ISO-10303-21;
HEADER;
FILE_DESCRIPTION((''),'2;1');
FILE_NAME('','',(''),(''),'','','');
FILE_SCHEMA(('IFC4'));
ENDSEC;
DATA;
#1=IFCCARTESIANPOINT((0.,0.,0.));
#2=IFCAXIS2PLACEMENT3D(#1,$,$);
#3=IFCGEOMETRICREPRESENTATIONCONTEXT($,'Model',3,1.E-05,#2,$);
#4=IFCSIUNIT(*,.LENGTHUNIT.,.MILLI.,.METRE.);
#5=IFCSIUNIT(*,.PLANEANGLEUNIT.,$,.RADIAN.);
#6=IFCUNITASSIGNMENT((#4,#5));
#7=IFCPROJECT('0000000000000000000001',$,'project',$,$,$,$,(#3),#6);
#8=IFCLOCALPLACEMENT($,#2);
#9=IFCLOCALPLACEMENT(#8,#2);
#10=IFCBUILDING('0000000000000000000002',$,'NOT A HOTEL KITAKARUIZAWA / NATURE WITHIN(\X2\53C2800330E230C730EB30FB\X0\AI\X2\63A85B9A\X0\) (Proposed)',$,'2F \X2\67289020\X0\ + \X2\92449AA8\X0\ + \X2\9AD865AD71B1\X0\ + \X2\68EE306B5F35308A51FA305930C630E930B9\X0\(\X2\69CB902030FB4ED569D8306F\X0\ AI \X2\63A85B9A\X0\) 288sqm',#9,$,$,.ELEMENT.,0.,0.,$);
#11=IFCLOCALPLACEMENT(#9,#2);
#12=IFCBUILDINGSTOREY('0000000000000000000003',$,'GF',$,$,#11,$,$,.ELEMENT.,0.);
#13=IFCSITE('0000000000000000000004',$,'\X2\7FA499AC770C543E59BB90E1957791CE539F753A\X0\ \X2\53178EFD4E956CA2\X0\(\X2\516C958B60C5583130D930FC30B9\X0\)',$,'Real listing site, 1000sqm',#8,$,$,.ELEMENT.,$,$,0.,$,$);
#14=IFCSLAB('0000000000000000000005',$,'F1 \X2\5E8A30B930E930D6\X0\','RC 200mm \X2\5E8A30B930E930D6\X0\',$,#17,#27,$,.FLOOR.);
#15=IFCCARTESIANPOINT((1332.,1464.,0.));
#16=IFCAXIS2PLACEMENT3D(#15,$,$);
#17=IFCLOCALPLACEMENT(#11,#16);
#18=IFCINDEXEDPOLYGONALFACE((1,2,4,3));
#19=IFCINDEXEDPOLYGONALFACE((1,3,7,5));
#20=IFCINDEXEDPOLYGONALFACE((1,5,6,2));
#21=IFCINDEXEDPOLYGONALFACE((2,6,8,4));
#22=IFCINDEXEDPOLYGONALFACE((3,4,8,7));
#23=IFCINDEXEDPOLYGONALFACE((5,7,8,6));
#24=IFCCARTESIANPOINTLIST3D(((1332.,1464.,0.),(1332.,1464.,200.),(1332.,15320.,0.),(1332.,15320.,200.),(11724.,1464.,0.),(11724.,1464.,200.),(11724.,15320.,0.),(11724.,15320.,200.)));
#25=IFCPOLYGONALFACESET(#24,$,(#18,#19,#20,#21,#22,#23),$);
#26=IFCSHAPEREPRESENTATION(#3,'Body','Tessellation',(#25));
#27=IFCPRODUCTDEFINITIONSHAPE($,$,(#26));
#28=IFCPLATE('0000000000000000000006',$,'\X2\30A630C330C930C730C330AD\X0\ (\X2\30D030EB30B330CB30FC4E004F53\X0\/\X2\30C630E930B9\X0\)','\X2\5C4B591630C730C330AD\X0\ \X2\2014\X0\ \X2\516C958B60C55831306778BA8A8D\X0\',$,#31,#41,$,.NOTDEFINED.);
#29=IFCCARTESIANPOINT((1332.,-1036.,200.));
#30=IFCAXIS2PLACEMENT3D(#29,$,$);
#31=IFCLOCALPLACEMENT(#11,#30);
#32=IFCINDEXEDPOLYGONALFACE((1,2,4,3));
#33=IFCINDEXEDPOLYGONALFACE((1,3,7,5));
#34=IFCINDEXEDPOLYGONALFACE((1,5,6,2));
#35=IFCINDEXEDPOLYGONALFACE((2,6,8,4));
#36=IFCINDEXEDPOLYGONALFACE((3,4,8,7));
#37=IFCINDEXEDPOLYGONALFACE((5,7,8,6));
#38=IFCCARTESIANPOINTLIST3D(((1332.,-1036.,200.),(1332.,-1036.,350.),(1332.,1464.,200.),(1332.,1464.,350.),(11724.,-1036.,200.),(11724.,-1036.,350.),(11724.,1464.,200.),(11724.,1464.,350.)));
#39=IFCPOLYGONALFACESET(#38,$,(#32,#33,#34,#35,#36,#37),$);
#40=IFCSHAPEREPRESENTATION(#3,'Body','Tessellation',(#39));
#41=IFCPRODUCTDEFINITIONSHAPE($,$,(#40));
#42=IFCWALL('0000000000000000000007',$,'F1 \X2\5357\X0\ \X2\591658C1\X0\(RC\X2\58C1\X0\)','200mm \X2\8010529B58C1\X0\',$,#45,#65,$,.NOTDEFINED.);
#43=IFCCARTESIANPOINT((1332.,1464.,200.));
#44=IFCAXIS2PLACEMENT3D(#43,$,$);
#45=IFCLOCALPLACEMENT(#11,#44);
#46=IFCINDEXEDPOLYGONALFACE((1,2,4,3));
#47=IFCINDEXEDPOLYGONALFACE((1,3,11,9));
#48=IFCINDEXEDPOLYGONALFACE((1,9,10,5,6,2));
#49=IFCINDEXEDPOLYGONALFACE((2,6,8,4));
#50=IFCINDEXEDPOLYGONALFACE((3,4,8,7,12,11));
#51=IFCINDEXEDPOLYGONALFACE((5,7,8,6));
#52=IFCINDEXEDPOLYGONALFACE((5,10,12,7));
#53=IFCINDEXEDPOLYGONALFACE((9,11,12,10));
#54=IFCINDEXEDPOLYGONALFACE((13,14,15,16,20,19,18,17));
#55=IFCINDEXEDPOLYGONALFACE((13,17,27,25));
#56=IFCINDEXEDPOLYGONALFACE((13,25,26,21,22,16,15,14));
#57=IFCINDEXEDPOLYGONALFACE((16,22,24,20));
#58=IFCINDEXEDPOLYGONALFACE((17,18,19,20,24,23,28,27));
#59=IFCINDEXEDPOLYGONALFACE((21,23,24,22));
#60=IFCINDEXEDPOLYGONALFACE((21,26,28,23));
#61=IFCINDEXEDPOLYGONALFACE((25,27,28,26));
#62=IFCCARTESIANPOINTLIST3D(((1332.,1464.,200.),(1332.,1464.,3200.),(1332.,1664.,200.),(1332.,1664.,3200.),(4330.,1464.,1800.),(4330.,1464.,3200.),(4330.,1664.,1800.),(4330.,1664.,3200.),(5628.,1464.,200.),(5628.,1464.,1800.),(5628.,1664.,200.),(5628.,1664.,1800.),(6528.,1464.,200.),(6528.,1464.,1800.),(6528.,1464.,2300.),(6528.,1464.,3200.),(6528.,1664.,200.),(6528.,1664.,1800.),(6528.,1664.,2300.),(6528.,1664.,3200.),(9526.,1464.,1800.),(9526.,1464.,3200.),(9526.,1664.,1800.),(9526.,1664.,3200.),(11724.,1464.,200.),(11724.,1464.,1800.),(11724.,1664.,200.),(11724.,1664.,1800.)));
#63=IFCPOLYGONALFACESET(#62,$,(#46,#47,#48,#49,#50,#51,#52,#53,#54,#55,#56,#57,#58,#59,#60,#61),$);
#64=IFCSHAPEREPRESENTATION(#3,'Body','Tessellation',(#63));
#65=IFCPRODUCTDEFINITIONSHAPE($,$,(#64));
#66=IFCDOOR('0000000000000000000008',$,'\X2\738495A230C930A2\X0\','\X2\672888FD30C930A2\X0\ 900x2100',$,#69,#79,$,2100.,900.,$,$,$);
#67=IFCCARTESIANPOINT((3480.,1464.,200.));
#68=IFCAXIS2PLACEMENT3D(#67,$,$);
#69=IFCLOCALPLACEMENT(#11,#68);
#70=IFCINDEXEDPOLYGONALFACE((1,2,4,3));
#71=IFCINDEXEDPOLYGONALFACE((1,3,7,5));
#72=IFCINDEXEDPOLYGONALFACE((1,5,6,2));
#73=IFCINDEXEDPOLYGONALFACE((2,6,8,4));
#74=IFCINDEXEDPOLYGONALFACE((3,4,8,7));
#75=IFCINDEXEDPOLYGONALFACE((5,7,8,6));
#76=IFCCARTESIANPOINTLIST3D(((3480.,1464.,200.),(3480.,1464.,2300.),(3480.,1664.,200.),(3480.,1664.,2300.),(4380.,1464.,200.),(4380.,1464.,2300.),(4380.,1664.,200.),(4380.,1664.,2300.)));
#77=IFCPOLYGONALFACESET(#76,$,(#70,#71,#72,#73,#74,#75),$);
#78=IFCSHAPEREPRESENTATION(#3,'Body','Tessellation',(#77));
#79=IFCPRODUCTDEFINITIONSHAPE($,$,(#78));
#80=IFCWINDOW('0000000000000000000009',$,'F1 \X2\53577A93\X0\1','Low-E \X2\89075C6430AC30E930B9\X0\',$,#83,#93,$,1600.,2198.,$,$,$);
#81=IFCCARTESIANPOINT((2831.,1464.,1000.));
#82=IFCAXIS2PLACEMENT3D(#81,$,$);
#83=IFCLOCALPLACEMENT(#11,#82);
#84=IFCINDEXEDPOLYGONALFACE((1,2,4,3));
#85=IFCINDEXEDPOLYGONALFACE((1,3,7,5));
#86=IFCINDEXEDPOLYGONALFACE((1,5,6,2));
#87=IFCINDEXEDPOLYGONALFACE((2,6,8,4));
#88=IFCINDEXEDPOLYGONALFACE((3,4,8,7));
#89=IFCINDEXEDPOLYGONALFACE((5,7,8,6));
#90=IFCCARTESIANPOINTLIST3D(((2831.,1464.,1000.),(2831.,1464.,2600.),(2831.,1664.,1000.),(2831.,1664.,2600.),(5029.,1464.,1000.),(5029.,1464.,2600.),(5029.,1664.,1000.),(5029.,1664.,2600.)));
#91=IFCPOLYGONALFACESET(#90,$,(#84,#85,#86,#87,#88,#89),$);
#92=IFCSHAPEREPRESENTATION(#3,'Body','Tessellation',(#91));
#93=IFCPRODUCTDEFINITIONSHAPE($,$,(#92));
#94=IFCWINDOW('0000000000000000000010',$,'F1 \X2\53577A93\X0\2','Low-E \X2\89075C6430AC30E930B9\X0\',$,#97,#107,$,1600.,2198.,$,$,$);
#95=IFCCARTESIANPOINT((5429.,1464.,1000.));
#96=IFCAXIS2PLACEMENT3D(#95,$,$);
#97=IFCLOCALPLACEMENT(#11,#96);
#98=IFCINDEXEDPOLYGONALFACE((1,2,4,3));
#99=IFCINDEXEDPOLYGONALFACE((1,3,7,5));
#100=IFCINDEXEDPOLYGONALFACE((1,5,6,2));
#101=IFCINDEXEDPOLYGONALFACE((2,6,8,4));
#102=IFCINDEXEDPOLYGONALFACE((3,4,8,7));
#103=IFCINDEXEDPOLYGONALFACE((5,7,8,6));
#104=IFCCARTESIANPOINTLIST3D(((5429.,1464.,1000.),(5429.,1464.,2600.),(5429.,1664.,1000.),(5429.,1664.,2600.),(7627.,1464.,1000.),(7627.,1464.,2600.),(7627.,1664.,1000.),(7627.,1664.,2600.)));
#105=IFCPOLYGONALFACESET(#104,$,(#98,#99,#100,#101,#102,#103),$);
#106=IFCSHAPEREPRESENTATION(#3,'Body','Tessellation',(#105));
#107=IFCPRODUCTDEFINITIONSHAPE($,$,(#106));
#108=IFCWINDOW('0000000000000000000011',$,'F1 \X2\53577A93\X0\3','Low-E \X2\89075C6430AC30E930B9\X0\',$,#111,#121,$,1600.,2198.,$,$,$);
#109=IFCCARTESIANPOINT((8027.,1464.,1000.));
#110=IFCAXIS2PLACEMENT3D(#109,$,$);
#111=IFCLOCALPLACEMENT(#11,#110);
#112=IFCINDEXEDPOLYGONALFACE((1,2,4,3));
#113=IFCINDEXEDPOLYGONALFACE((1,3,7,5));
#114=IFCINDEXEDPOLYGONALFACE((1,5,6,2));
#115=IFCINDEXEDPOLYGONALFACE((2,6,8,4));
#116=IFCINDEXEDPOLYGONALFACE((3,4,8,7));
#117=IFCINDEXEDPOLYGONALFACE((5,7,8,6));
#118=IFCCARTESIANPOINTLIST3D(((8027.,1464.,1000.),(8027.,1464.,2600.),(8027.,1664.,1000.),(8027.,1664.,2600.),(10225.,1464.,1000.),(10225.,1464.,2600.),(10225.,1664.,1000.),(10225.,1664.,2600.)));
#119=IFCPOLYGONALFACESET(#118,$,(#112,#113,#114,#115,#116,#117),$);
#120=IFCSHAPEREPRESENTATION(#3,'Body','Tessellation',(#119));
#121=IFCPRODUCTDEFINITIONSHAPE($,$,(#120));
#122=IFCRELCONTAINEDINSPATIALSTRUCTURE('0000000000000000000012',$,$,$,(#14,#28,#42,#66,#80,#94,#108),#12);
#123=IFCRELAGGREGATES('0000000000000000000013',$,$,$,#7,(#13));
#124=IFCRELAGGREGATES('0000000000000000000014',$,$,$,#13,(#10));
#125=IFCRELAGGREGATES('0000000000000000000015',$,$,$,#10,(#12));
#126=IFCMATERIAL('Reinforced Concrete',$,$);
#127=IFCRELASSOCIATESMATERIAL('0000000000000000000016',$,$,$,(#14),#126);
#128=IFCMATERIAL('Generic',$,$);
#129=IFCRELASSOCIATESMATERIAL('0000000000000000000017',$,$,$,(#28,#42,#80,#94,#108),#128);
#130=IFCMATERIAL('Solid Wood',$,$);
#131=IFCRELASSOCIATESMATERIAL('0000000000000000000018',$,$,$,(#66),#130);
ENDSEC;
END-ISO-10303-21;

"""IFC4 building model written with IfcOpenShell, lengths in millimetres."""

from ifc_helpers import new_model, si_unit, frame, frame_2d, origin, place, context, project, spatial, rectangle, extrude, material, element, fill, save


model = new_model("IFC4")

# Units and contexts
model_context = context("Model", 3, precision=1e-05, world=origin())
ifc_project = project(units=[si_unit("LENGTHUNIT", "METRE", prefix="MILLI"), si_unit("PLANEANGLEUNIT", "RADIAN")], contexts=[model_context])

# Site, building, storey
site_placement = place(None, origin())
site = spatial("IfcSite", under=ifc_project, at=site_placement, Name="群馬県吾妻郡長野原町 北軽井沢(公開情報ベース)", ObjectType="Real listing site, 1000sqm", CompositionType="ELEMENT", RefElevation=0.0)
building_placement = place(site_placement, origin())
building = spatial("IfcBuilding", under=site, at=building_placement, Name="NOT A HOTEL KITAKARUIZAWA / NATURE WITHIN(参考モデル・AI推定) (Proposed)", ObjectType="2F 木造 + 鉄骨 + 高断熱 + 森に張り出すテラス(構造・仕様は AI 推定) 288sqm", CompositionType="ELEMENT", ElevationOfRefHeight=0.0, ElevationOfTerrain=0.0)
storey_placement = place(building_placement, origin())
storey = spatial("IfcBuildingStorey", under=building, at=storey_placement, Name="GF", CompositionType="ELEMENT", Elevation=0.0)

# Slab
ifc_material_1 = material(Name="Reinforced Concrete")
slab_placement = place(storey_placement, frame((1332.0, 1464.0, 0.0)))
element("IfcSlab", 1, at=slab_placement, inside=storey, material=ifc_material_1, Name="F1 床スラブ", Description="RC 200mm 床スラブ", PredefinedType="FLOOR", context=model_context, shape_type="SweptSolid", body=[
    extrude(rectangle(XDim=10392.0, YDim=13856.0, at=frame_2d((5196.0, 6928.0))), frame((1332.0, 1464.0, 0.0)), (0.0, 0.0, 1.0), 200.0),
])

# Plate
ifc_material_2 = material(Name="Generic")
plate_placement = place(storey_placement, frame((1332.0, -1036.0, 200.0)))
element("IfcPlate", 2, at=plate_placement, inside=storey, material=ifc_material_2, Name="ウッドデッキ (バルコニー一体/テラス)", Description="屋外デッキ — 公開情報で確認", PredefinedType="NOTDEFINED", context=model_context, shape_type="SweptSolid", body=[
    extrude(rectangle(XDim=10392.0, YDim=2500.0, at=frame_2d((5196.0, 1250.0))), frame((1332.0, -1036.0, 200.0)), (0.0, 0.0, 1.0), 150.0),
])

# Wall, openings, door, windows
wall_1_placement = place(storey_placement, frame((1332.0, 1464.0, 200.0)))
wall_1 = element("IfcWall", 3, at=wall_1_placement, inside=storey, material=ifc_material_2, Name="F1 南 外壁(RC壁)", Description="200mm 耐力壁", PredefinedType="NOTDEFINED", context=model_context, shape_type="SweptSolid", body=[
    extrude(rectangle(XDim=10392.0, YDim=200.0, at=frame_2d((5196.0, 100.0))), frame((1332.0, 1464.0, 200.0)), (0.0, 0.0, 1.0), 3000.0),
])
opening_1_placement = place(storey_placement, frame((3480.0, 1464.0, 200.0)))
opening_1 = element("IfcOpeningElement", 4, at=opening_1_placement, cuts=wall_1, PredefinedType="NOTDEFINED", context=model_context, shape_type="SweptSolid", body=[
    extrude(rectangle(XDim=900.0, YDim=200.0, at=frame_2d((450.0, 100.0))), frame((3480.0, 1464.0, 200.0)), (0.0, 0.0, 1.0), 2100.0),
])
opening_2_placement = place(storey_placement, frame((2831.0, 1464.0, 1000.0)))
opening_2 = element("IfcOpeningElement", 5, at=opening_2_placement, cuts=wall_1, PredefinedType="NOTDEFINED", context=model_context, shape_type="SweptSolid", body=[
    extrude(rectangle(XDim=2198.0, YDim=200.0, at=frame_2d((1099.0, 100.0))), frame((2831.0, 1464.0, 1000.0)), (0.0, 0.0, 1.0), 1600.0),
])
opening_3_placement = place(storey_placement, frame((5429.0, 1464.0, 1000.0)))
opening_3 = element("IfcOpeningElement", 6, at=opening_3_placement, cuts=wall_1, PredefinedType="NOTDEFINED", context=model_context, shape_type="SweptSolid", body=[
    extrude(rectangle(XDim=2198.0, YDim=200.0, at=frame_2d((1099.0, 100.0))), frame((5429.0, 1464.0, 1000.0)), (0.0, 0.0, 1.0), 1600.0),
])
opening_4_placement = place(storey_placement, frame((8027.0, 1464.0, 1000.0)))
opening_4 = element("IfcOpeningElement", 7, at=opening_4_placement, cuts=wall_1, PredefinedType="NOTDEFINED", context=model_context, shape_type="SweptSolid", body=[
    extrude(rectangle(XDim=2198.0, YDim=200.0, at=frame_2d((1099.0, 100.0))), frame((8027.0, 1464.0, 1000.0)), (0.0, 0.0, 1.0), 1600.0),
])
ifc_material_3 = material(Name="Solid Wood")
door_placement = place(storey_placement, frame((3480.0, 1464.0, 200.0)))
door = element("IfcDoor", 8, at=door_placement, inside=storey, material=ifc_material_3, Name="玄関ドア", Description="木製ドア 900x2100", OverallHeight=2100.0, OverallWidth=900.0, context=model_context, shape_type="SweptSolid", body=[
    extrude(rectangle(XDim=900.0, YDim=200.0, at=frame_2d((450.0, 100.0))), frame((3480.0, 1464.0, 200.0)), (0.0, 0.0, 1.0), 2100.0),
])
fill(opening_1, door)
window_1_placement = place(storey_placement, frame((2831.0, 1464.0, 1000.0)))
window_1 = element("IfcWindow", 9, at=window_1_placement, inside=storey, material=ifc_material_2, Name="F1 南窓1", Description="Low-E 複層ガラス", OverallHeight=1600.0, OverallWidth=2198.0, context=model_context, shape_type="SweptSolid", body=[
    extrude(rectangle(XDim=2198.0, YDim=200.0, at=frame_2d((1099.0, 100.0))), frame((2831.0, 1464.0, 1000.0)), (0.0, 0.0, 1.0), 1600.0),
])
fill(opening_2, window_1)
window_2_placement = place(storey_placement, frame((5429.0, 1464.0, 1000.0)))
window_2 = element("IfcWindow", 10, at=window_2_placement, inside=storey, material=ifc_material_2, Name="F1 南窓2", Description="Low-E 複層ガラス", OverallHeight=1600.0, OverallWidth=2198.0, context=model_context, shape_type="SweptSolid", body=[
    extrude(rectangle(XDim=2198.0, YDim=200.0, at=frame_2d((1099.0, 100.0))), frame((5429.0, 1464.0, 1000.0)), (0.0, 0.0, 1.0), 1600.0),
])
fill(opening_3, window_2)
window_3_placement = place(storey_placement, frame((8027.0, 1464.0, 1000.0)))
window_3 = element("IfcWindow", 11, at=window_3_placement, inside=storey, material=ifc_material_2, Name="F1 南窓3", Description="Low-E 複層ガラス", OverallHeight=1600.0, OverallWidth=2198.0, context=model_context, shape_type="SweptSolid", body=[
    extrude(rectangle(XDim=2198.0, YDim=200.0, at=frame_2d((1099.0, 100.0))), frame((8027.0, 1464.0, 1000.0)), (0.0, 0.0, 1.0), 1600.0),
])
fill(opening_4, window_3)

save(model, "model.ifc")
